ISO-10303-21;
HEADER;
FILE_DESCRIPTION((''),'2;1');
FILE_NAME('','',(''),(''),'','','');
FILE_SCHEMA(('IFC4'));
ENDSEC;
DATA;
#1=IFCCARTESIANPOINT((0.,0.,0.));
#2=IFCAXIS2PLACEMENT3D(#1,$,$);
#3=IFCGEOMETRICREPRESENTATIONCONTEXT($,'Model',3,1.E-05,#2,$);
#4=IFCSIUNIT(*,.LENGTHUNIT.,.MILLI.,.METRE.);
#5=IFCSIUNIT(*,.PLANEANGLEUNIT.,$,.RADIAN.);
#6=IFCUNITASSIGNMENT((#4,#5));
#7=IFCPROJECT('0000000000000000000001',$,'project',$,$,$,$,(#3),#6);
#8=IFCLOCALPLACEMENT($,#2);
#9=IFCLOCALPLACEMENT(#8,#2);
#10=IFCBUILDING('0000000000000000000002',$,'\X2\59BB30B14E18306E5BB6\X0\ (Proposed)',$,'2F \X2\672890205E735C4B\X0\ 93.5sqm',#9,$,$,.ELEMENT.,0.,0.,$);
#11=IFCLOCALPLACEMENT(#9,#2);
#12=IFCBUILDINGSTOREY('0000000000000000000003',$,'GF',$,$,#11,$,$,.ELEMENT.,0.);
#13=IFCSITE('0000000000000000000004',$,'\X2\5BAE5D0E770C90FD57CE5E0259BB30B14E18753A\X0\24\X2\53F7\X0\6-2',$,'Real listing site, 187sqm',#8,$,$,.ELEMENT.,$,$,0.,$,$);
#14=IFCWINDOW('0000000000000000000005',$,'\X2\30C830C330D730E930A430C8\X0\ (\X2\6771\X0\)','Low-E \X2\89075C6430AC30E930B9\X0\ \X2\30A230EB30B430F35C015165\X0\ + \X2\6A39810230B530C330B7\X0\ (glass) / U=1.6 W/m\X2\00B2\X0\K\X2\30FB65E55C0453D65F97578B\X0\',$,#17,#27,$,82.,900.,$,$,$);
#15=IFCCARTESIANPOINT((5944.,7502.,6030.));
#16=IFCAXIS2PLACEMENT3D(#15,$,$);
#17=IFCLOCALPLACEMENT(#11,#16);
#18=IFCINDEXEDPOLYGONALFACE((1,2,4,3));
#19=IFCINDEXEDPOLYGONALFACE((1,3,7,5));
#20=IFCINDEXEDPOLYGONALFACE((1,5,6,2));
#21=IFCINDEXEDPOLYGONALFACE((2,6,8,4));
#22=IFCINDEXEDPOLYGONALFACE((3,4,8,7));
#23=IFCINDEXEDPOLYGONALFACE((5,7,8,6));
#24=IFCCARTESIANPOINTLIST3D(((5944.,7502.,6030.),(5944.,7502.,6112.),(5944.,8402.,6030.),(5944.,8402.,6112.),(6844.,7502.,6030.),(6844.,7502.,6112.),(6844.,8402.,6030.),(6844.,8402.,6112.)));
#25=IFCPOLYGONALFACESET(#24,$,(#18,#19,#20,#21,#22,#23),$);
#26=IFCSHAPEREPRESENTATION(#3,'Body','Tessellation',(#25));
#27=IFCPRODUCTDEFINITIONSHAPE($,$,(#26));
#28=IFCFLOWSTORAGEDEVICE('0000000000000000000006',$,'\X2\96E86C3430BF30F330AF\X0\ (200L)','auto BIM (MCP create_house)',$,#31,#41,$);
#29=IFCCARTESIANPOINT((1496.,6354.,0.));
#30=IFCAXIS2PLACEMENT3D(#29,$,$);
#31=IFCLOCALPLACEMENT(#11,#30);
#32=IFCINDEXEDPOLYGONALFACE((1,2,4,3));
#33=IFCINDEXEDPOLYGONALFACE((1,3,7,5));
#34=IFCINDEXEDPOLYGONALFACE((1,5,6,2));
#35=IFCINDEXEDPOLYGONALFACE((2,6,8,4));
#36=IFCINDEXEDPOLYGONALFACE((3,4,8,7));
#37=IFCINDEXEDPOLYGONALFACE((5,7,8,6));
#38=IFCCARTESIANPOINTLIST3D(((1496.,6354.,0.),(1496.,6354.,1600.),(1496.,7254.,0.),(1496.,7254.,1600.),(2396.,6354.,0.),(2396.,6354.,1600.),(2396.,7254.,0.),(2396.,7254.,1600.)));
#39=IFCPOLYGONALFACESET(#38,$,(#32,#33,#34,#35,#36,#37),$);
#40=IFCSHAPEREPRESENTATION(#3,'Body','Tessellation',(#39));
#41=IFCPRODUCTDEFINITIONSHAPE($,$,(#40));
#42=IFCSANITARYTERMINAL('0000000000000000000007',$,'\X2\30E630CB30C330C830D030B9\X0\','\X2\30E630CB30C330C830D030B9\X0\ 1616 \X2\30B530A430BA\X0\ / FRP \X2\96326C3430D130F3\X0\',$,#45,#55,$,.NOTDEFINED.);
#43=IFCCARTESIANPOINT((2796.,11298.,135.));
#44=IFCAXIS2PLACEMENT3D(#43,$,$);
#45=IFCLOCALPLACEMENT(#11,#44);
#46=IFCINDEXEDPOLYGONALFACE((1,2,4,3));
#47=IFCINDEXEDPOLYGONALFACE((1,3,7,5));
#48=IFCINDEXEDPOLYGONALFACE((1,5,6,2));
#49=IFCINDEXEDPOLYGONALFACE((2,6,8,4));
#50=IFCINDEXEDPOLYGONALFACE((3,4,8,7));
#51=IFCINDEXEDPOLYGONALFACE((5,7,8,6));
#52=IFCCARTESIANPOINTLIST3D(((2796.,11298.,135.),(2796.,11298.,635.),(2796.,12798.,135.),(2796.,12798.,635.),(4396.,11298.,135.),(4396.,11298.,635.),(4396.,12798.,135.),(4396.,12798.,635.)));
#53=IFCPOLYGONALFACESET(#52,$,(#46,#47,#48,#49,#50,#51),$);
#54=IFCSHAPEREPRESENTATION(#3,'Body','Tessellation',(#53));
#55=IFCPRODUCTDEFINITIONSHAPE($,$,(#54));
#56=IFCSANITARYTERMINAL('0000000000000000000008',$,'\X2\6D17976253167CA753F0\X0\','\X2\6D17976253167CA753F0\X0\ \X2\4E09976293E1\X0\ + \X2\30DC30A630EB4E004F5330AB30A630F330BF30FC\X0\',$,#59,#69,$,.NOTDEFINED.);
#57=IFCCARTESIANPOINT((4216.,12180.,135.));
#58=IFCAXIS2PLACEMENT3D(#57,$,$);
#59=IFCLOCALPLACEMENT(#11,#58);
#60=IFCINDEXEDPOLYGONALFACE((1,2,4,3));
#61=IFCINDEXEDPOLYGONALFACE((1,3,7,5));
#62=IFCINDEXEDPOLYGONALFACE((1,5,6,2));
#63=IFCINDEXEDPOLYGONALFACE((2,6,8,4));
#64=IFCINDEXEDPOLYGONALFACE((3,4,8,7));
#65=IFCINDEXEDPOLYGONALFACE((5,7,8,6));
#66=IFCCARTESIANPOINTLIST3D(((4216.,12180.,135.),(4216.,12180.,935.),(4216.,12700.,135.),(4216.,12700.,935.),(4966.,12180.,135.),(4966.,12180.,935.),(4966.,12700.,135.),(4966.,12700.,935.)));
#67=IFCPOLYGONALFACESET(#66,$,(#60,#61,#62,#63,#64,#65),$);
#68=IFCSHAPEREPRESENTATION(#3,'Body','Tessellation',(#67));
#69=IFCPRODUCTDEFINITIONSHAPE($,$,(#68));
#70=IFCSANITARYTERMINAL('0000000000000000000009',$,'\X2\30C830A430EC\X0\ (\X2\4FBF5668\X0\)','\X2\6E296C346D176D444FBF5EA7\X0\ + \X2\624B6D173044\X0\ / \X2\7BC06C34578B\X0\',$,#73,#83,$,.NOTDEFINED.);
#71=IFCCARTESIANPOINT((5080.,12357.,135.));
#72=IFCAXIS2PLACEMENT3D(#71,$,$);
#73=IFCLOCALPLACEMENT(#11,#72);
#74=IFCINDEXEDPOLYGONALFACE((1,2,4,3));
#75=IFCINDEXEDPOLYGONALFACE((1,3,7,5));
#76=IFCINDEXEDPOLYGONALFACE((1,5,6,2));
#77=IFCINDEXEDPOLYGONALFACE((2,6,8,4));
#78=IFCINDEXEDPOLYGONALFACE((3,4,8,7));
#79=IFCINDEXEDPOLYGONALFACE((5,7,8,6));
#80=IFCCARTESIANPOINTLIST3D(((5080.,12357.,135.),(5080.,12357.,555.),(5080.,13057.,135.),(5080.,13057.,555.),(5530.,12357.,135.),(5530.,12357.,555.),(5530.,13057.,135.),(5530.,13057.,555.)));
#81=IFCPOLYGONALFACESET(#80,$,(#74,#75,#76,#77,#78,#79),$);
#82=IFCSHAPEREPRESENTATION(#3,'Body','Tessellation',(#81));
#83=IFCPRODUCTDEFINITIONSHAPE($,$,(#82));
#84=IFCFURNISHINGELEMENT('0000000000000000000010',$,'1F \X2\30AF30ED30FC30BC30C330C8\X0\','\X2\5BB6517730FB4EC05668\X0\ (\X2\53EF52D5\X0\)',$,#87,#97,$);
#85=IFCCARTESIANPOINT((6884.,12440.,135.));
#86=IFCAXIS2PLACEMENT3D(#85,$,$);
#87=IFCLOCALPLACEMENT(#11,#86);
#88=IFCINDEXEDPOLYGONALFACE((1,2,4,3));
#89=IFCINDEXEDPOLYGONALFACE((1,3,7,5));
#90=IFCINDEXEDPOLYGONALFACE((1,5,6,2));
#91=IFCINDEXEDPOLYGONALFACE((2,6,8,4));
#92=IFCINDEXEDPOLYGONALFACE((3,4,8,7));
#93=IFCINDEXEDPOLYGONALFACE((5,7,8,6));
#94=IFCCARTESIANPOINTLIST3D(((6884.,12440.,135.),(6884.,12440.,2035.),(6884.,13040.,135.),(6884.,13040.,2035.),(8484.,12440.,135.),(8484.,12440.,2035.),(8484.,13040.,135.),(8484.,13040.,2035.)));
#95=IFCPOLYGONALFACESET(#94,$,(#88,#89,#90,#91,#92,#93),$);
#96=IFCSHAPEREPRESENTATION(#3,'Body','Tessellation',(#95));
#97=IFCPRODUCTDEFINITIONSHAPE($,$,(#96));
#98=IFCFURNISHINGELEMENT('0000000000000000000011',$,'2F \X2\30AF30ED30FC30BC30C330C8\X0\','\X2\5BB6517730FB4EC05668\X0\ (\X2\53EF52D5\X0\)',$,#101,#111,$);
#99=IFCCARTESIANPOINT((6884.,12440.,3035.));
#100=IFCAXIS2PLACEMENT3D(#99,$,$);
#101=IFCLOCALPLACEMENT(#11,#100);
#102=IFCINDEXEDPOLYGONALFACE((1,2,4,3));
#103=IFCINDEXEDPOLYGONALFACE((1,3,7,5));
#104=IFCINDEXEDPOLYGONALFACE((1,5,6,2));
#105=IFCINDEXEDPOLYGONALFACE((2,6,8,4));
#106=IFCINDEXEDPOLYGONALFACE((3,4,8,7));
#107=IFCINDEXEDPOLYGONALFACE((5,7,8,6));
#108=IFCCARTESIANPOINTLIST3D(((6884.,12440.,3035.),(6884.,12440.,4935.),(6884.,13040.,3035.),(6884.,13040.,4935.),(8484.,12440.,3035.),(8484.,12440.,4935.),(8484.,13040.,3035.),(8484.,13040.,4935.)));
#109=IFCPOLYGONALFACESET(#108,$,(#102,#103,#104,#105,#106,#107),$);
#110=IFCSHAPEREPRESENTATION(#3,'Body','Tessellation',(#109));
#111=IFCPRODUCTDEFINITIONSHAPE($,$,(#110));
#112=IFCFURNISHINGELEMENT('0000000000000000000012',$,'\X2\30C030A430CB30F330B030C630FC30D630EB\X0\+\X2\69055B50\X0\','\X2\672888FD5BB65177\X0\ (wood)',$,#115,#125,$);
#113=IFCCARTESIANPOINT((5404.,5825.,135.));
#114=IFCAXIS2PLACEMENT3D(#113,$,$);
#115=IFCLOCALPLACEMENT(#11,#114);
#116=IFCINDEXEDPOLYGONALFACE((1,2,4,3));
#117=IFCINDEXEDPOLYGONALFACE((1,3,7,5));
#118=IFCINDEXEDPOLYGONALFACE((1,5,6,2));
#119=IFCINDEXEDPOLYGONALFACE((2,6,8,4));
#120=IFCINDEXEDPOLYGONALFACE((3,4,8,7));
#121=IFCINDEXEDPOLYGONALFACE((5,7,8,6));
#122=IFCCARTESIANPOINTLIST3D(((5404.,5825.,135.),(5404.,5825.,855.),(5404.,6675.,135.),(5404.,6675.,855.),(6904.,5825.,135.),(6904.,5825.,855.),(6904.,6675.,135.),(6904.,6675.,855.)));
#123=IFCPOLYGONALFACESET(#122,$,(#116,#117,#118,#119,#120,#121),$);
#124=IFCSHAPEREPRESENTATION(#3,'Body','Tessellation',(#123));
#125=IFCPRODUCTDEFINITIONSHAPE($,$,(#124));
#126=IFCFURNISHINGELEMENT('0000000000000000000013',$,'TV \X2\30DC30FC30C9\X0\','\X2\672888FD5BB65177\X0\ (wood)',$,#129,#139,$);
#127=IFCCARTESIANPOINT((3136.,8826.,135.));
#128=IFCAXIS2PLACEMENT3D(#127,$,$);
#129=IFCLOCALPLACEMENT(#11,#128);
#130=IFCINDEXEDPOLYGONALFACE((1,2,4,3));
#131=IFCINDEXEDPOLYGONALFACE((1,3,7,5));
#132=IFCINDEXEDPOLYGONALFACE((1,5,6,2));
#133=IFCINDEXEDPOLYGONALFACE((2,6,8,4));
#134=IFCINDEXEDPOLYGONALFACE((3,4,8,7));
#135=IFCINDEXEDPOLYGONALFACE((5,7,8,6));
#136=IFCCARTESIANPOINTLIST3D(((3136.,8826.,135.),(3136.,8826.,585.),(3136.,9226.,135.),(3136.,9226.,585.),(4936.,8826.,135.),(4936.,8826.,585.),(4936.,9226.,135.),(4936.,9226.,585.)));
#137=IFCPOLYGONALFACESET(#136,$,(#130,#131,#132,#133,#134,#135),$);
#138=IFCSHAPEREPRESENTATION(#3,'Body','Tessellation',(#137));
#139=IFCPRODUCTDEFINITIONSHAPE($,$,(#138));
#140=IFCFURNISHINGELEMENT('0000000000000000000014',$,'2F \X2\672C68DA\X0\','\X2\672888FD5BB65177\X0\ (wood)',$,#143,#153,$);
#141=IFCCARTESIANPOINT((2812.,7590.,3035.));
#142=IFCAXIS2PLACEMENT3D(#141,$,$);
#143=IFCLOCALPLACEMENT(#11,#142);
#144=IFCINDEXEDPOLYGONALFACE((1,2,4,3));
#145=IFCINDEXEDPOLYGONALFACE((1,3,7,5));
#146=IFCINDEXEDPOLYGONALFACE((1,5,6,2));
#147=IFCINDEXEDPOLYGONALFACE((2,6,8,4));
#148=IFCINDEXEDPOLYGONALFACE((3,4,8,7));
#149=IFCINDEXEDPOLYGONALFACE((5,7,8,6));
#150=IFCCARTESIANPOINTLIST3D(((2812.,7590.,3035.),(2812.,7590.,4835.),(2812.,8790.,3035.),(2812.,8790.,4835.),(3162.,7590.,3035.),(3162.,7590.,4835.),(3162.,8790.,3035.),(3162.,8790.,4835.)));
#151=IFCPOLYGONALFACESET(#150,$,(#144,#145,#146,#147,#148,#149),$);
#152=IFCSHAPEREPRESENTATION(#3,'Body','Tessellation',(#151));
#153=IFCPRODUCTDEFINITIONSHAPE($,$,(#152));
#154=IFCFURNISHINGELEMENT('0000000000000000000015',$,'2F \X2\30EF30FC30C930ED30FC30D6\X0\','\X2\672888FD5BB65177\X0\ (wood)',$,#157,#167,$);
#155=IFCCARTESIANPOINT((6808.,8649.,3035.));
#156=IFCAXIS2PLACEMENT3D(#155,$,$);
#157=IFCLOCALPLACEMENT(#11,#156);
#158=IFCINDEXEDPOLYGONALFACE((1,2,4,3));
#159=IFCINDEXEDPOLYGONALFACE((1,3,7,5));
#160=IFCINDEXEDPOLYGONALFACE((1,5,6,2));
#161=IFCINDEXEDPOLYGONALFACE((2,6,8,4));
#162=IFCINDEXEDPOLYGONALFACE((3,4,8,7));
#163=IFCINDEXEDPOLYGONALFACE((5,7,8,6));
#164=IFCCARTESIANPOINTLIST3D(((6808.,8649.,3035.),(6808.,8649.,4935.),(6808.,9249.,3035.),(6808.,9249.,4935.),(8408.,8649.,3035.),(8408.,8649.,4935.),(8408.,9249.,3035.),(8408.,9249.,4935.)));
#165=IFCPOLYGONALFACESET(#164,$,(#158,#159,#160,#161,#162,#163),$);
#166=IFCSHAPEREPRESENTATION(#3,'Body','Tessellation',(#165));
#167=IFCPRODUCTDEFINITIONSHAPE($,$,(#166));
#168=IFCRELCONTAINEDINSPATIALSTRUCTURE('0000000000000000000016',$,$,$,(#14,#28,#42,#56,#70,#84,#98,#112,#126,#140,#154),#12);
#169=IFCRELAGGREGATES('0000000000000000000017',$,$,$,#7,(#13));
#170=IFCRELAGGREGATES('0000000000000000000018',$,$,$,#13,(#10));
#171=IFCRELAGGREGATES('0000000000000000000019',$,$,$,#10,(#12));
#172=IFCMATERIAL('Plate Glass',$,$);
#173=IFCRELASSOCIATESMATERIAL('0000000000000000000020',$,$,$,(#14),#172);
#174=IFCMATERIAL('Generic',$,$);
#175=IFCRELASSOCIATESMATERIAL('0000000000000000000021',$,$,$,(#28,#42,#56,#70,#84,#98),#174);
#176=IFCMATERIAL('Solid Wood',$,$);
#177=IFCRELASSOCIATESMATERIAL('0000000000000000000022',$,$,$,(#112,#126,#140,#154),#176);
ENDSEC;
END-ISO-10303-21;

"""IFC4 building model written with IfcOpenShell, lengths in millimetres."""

from ifc_helpers import new_model, si_unit, frame, frame_2d, origin, place, context, project, spatial, rectangle, extrude, material, element, save


model = new_model("IFC4")

# Units and contexts
model_context = context("Model", 3, precision=1e-05, world=origin())
ifc_project = project(units=[si_unit("LENGTHUNIT", "METRE", prefix="MILLI"), si_unit("PLANEANGLEUNIT", "RADIAN")], contexts=[model_context])

# Site, building, storey
site_placement = place(None, origin())
site = spatial("IfcSite", under=ifc_project, at=site_placement, Name="宮崎県都城市妻ケ丘町24号6-2", ObjectType="Real listing site, 187sqm", CompositionType="ELEMENT", RefElevation=0.0)
building_placement = place(site_placement, origin())
building = spatial("IfcBuilding", under=site, at=building_placement, Name="妻ケ丘の家 (Proposed)", ObjectType="2F 木造平屋 93.5sqm", CompositionType="ELEMENT", ElevationOfRefHeight=0.0, ElevationOfTerrain=0.0)
storey_placement = place(building_placement, origin())
storey = spatial("IfcBuildingStorey", under=building, at=storey_placement, Name="GF", CompositionType="ELEMENT", Elevation=0.0)

# Shared definitions
ifc_material_1 = material(Name="Solid Wood")
ifc_material_2 = material(Name="Plate Glass")

# Window
window_1_placement = place(storey_placement, frame((5944.0, 7502.0, 6030.0)))
element("IfcWindow", 1, at=window_1_placement, inside=storey, material=ifc_material_2, Name="トップライト (東)", Description="Low-E 複層ガラス アルゴン封入 + 樹脂サッシ (glass) / U=1.6 W/m²K・日射取得型", OverallHeight=82.0, OverallWidth=900.0, context=model_context, shape_type="SweptSolid", body=[
    extrude(rectangle(XDim=900.0, YDim=900.0, at=frame_2d((450.0, 450.0))), frame((5944.0, 7502.0, 6030.0)), (0.0, 0.0, 1.0), 82.0),
])

# Flow storage device
ifc_material_3 = material(Name="Generic")
flow_storage_device_placement = place(storey_placement, frame((1496.0, 6354.0, 0.0)))
element("IfcFlowStorageDevice", 2, at=flow_storage_device_placement, inside=storey, material=ifc_material_3, Name="雨水タンク (200L)", Description="auto BIM (MCP create_house)", context=model_context, shape_type="SweptSolid", body=[
    extrude(rectangle(XDim=900.0, YDim=900.0, at=frame_2d((450.0, 450.0))), frame((1496.0, 6354.0, 0.0)), (0.0, 0.0, 1.0), 1600.0),
])

# Sanitary terminals
sanitary_terminal_1_placement = place(storey_placement, frame((2796.0, 11298.0, 135.0)))
element("IfcSanitaryTerminal", 3, at=sanitary_terminal_1_placement, inside=storey, material=ifc_material_3, Name="ユニットバス", Description="ユニットバス 1616 サイズ / FRP 防水パン", PredefinedType="NOTDEFINED", context=model_context, shape_type="SweptSolid", body=[
    extrude(rectangle(XDim=1600.0, YDim=1500.0, at=frame_2d((800.0, 750.0))), frame((2796.0, 11298.0, 135.0)), (0.0, 0.0, 1.0), 500.0),
])
sanitary_terminal_2_placement = place(storey_placement, frame((4216.0, 12180.0, 135.0)))
element("IfcSanitaryTerminal", 4, at=sanitary_terminal_2_placement, inside=storey, material=ifc_material_3, Name="洗面化粧台", Description="洗面化粧台 三面鏡 + ボウル一体カウンター", PredefinedType="NOTDEFINED", context=model_context, shape_type="SweptSolid", body=[
    extrude(rectangle(XDim=750.0, YDim=520.0, at=frame_2d((375.0, 260.0))), frame((4216.0, 12180.0, 135.0)), (0.0, 0.0, 1.0), 800.0),
])
sanitary_terminal_3_placement = place(storey_placement, frame((5080.0, 12357.0, 135.0)))
element("IfcSanitaryTerminal", 5, at=sanitary_terminal_3_placement, inside=storey, material=ifc_material_3, Name="トイレ (便器)", Description="温水洗浄便座 + 手洗い / 節水型", PredefinedType="NOTDEFINED", context=model_context, shape_type="SweptSolid", body=[
    extrude(rectangle(XDim=450.0, YDim=700.0, at=frame_2d((225.0, 350.0))), frame((5080.0, 12357.0, 135.0)), (0.0, 0.0, 1.0), 420.0),
])

# Furnishing elements
furnishing_1_placement = place(storey_placement, frame((6884.0, 12440.0, 135.0)))
element("IfcFurnishingElement", 6, at=furnishing_1_placement, inside=storey, material=ifc_material_3, Name="1F クローゼット", Description="家具・什器 (可動)", context=model_context, shape_type="SweptSolid", body=[
    extrude(rectangle(XDim=1600.0, YDim=600.0, at=frame_2d((800.0, 300.0))), frame((6884.0, 12440.0, 135.0)), (0.0, 0.0, 1.0), 1900.0),
])
furnishing_2_placement = place(storey_placement, frame((6884.0, 12440.0, 3035.0)))
element("IfcFurnishingElement", 7, at=furnishing_2_placement, inside=storey, material=ifc_material_3, Name="2F クローゼット", Description="家具・什器 (可動)", context=model_context, shape_type="SweptSolid", body=[
    extrude(rectangle(XDim=1600.0, YDim=600.0, at=frame_2d((800.0, 300.0))), frame((6884.0, 12440.0, 3035.0)), (0.0, 0.0, 1.0), 1900.0),
])
furnishing_3_placement = place(storey_placement, frame((5404.0, 5825.0, 135.0)))
element("IfcFurnishingElement", 8, at=furnishing_3_placement, inside=storey, material=ifc_material_1, Name="ダイニングテーブル+椅子", Description="木製家具 (wood)", context=model_context, shape_type="SweptSolid", body=[
    extrude(rectangle(XDim=1500.0, YDim=850.0, at=frame_2d((750.0, 425.0))), frame((5404.0, 5825.0, 135.0)), (0.0, 0.0, 1.0), 720.0),
])
furnishing_4_placement = place(storey_placement, frame((3136.0, 8826.0, 135.0)))
element("IfcFurnishingElement", 9, at=furnishing_4_placement, inside=storey, material=ifc_material_1, Name="TV ボード", Description="木製家具 (wood)", context=model_context, shape_type="SweptSolid", body=[
    extrude(rectangle(XDim=1800.0, YDim=400.0, at=frame_2d((900.0, 200.0))), frame((3136.0, 8826.0, 135.0)), (0.0, 0.0, 1.0), 450.0),
])
furnishing_5_placement = place(storey_placement, frame((2812.0, 7590.0, 3035.0)))
element("IfcFurnishingElement", 10, at=furnishing_5_placement, inside=storey, material=ifc_material_1, Name="2F 本棚", Description="木製家具 (wood)", context=model_context, shape_type="SweptSolid", body=[
    extrude(rectangle(XDim=350.0, YDim=1200.0, at=frame_2d((175.0, 600.0))), frame((2812.0, 7590.0, 3035.0)), (0.0, 0.0, 1.0), 1800.0),
])
furnishing_6_placement = place(storey_placement, frame((6808.0, 8649.0, 3035.0)))
element("IfcFurnishingElement", 11, at=furnishing_6_placement, inside=storey, material=ifc_material_1, Name="2F ワードローブ", Description="木製家具 (wood)", context=model_context, shape_type="SweptSolid", body=[
    extrude(rectangle(XDim=1600.0, YDim=600.0, at=frame_2d((800.0, 300.0))), frame((6808.0, 8649.0, 3035.0)), (0.0, 0.0, 1.0), 1900.0),
])

save(model, "model.ifc")
